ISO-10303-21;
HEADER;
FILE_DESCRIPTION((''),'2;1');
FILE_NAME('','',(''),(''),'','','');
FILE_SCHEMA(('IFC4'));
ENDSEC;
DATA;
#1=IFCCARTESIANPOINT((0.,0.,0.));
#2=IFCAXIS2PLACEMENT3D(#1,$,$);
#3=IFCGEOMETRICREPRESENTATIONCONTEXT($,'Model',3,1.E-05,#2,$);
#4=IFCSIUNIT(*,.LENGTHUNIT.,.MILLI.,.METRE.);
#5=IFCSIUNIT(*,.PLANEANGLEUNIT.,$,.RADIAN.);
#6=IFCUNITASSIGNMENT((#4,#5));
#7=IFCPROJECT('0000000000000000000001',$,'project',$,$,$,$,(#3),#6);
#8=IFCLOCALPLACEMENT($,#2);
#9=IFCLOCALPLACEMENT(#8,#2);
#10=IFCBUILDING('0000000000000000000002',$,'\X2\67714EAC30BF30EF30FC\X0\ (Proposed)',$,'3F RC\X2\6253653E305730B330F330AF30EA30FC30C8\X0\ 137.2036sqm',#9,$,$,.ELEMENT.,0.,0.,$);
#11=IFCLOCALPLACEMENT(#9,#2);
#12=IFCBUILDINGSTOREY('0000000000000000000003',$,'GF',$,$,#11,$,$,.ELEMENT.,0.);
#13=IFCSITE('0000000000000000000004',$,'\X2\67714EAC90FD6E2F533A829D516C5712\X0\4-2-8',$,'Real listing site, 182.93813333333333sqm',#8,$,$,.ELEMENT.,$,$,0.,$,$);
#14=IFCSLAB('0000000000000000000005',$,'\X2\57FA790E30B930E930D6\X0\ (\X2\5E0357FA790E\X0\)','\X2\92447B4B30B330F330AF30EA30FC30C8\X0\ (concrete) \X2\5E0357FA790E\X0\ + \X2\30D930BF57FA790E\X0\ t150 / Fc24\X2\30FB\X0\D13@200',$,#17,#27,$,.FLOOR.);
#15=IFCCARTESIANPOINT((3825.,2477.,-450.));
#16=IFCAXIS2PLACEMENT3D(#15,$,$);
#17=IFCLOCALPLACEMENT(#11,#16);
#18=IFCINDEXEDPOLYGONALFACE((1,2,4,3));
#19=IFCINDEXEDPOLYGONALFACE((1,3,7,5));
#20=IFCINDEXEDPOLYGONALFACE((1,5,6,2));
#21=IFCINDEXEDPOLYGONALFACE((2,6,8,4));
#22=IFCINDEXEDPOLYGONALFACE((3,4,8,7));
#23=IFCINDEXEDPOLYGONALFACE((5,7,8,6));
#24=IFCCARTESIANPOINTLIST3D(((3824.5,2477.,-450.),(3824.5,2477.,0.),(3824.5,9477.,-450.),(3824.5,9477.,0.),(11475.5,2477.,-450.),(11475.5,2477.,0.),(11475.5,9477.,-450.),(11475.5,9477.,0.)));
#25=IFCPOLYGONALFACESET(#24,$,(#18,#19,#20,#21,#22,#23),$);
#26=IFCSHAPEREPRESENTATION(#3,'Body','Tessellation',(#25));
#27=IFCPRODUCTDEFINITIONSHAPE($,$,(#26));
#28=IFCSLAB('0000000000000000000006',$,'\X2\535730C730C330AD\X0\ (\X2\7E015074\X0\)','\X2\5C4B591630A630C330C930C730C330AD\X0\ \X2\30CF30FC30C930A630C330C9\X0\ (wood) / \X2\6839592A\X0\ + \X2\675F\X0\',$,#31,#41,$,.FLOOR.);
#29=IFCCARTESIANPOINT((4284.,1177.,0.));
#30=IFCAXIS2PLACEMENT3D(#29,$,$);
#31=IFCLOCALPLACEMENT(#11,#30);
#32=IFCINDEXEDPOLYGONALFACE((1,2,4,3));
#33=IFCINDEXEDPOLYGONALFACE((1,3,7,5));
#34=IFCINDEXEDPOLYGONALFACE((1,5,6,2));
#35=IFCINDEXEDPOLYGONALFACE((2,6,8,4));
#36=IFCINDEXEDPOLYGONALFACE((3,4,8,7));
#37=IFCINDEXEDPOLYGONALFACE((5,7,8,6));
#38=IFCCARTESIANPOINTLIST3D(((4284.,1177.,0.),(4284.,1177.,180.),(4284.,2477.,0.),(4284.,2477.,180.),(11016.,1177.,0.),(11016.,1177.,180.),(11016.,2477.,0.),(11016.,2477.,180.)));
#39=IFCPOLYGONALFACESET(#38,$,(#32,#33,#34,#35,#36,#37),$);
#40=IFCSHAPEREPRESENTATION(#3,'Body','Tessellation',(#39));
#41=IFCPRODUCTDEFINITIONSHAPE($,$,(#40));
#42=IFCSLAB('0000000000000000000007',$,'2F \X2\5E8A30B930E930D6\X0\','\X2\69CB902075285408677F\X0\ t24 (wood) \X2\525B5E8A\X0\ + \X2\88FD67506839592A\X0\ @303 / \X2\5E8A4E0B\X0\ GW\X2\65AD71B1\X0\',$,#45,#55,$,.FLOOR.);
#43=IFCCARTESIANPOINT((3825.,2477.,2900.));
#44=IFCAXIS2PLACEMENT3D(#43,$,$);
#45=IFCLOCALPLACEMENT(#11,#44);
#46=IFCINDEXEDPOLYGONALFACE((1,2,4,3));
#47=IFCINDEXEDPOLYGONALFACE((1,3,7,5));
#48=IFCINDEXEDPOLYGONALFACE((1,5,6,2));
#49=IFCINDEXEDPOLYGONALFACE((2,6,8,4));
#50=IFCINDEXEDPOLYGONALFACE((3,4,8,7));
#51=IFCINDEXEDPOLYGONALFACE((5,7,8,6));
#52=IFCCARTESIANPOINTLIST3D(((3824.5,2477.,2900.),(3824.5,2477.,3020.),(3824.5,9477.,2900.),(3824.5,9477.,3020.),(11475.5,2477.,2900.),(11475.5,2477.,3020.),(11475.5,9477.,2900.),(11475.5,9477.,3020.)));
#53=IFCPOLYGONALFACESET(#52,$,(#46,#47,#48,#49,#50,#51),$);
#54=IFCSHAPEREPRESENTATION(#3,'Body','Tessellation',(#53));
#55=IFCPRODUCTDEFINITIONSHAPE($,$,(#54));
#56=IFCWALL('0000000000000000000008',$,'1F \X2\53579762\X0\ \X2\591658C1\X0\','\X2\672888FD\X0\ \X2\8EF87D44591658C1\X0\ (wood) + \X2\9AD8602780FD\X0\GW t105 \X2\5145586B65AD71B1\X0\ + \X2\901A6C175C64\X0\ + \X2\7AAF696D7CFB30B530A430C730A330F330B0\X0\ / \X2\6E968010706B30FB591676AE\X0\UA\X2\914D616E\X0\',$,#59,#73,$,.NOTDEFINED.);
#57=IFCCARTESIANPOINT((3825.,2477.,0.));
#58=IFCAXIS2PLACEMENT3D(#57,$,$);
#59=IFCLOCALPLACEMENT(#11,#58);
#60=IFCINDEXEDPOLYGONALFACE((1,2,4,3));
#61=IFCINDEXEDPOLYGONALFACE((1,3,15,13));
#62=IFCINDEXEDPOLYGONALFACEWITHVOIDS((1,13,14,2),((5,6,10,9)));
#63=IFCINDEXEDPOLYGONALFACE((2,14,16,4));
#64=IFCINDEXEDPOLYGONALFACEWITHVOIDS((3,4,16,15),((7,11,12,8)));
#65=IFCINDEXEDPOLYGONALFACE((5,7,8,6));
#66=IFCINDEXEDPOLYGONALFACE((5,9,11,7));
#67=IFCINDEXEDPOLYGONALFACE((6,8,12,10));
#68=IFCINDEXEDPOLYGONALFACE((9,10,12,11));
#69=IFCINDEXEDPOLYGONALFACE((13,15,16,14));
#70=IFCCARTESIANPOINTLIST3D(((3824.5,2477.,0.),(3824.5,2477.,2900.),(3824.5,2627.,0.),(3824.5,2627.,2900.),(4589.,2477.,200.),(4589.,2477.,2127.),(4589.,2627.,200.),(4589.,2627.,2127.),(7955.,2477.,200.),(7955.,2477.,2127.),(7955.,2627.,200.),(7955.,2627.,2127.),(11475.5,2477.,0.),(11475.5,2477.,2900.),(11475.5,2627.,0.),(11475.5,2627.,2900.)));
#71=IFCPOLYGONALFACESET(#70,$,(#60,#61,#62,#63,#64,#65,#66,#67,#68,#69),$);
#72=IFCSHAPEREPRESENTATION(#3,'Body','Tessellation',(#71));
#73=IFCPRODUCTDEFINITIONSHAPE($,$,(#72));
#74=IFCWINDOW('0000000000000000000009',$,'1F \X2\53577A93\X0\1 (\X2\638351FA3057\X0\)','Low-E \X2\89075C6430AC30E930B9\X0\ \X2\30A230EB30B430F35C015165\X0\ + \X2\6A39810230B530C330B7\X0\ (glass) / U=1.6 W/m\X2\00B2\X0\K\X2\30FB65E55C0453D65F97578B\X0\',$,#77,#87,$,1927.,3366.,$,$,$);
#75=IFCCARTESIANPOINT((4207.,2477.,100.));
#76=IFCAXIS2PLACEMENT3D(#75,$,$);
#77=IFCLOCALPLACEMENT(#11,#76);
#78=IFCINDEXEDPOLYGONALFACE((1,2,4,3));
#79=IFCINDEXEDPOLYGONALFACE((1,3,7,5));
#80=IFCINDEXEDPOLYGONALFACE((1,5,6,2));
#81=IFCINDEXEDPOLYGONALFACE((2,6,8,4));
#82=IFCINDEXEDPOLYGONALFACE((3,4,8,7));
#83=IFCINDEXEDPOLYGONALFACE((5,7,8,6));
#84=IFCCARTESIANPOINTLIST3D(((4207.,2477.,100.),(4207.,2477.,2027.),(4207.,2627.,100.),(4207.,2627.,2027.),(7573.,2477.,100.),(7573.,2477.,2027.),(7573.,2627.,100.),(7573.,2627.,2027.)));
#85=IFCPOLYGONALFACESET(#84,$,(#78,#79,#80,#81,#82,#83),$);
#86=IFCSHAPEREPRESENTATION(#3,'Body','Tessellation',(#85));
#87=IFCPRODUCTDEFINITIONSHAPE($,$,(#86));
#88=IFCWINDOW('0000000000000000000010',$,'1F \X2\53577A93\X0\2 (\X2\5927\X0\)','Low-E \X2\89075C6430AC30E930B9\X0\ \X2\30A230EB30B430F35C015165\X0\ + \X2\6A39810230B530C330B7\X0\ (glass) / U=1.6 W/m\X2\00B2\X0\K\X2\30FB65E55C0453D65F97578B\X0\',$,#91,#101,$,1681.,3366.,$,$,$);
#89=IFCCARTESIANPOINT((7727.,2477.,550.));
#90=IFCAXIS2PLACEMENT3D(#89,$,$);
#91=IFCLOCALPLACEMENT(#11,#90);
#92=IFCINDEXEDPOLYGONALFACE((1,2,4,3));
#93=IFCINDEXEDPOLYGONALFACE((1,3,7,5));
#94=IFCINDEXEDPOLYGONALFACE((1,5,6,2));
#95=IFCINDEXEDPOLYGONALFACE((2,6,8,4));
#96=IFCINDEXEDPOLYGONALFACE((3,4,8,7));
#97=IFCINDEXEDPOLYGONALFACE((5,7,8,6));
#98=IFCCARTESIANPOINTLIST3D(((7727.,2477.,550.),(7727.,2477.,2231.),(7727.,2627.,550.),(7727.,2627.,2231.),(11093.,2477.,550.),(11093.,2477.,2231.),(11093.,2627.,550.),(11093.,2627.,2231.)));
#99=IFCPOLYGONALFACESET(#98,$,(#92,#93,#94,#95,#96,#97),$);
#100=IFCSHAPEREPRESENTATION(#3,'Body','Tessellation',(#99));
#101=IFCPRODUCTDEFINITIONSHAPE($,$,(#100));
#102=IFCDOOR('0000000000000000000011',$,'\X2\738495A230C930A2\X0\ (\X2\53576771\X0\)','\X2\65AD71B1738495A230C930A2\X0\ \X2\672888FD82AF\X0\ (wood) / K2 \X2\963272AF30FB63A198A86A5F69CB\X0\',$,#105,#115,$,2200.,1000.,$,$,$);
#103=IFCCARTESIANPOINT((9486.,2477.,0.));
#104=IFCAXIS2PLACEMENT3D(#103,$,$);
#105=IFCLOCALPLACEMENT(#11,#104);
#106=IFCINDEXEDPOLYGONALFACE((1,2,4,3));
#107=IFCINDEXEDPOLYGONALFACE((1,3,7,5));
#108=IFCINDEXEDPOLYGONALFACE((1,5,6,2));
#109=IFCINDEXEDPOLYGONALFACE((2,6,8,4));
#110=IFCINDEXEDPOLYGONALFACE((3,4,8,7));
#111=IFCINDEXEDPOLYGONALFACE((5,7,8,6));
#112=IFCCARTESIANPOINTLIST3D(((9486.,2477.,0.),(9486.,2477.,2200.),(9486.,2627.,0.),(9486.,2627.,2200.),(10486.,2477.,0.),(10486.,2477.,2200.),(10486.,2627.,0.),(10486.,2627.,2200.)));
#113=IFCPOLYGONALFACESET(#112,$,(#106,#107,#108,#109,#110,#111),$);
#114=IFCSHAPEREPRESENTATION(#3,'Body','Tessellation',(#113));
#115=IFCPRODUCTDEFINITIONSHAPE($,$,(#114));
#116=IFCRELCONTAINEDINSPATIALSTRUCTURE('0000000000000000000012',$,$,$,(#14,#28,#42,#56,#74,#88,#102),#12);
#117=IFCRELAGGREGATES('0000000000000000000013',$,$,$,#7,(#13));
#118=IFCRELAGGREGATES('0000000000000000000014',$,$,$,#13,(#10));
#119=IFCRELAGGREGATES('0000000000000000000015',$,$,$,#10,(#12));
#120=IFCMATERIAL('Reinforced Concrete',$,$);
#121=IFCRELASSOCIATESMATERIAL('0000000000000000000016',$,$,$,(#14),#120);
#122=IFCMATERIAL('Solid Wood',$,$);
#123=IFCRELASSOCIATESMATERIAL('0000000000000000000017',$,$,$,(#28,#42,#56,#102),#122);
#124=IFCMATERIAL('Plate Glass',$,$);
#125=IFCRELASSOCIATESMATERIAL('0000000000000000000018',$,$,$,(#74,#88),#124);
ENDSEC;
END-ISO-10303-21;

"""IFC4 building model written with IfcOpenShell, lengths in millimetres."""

from ifc_helpers import new_model, si_unit, frame, frame_2d, origin, place, context, project, spatial, rectangle, extrude, material, element, fill, save


model = new_model("IFC4")

# Units and contexts
model_context = context("Model", 3, precision=1e-05, world=origin())
ifc_project = project(units=[si_unit("LENGTHUNIT", "METRE", prefix="MILLI"), si_unit("PLANEANGLEUNIT", "RADIAN")], contexts=[model_context])

# Site, building, storey
site_placement = place(None, origin())
site = spatial("IfcSite", under=ifc_project, at=site_placement, Name="東京都港区芝公園4-2-8", ObjectType="Real listing site, 182.93813333333333sqm", CompositionType="ELEMENT", RefElevation=0.0)
building_placement = place(site_placement, origin())
building = spatial("IfcBuilding", under=site, at=building_placement, Name="東京タワー (Proposed)", ObjectType="3F RC打放しコンクリート 137.2036sqm", CompositionType="ELEMENT", ElevationOfRefHeight=0.0, ElevationOfTerrain=0.0)
storey_placement = place(building_placement, origin())
storey = spatial("IfcBuildingStorey", under=building, at=storey_placement, Name="GF", CompositionType="ELEMENT", Elevation=0.0)

# Slabs
ifc_material_1 = material(Name="Reinforced Concrete")
slab_1_placement = place(storey_placement, frame((3825.0, 2477.0, -450.0)))
element("IfcSlab", 1, at=slab_1_placement, inside=storey, material=ifc_material_1, Name="基礎スラブ (布基礎)", Description="鉄筋コンクリート (concrete) 布基礎 + ベタ基礎 t150 / Fc24・D13@200", PredefinedType="FLOOR", context=model_context, shape_type="SweptSolid", body=[
    extrude(rectangle(XDim=7651.0, YDim=7000.0, at=frame_2d((3825.0, 3500.0))), frame((3825.0, 2477.0, -450.0)), (0.0, 0.0, 1.0), 450.0),
])
ifc_material_2 = material(Name="Solid Wood")
slab_2_placement = place(storey_placement, frame((4284.0, 1177.0, 0.0)))
element("IfcSlab", 2, at=slab_2_placement, inside=storey, material=ifc_material_2, Name="南デッキ (縁側)", Description="屋外ウッドデッキ ハードウッド (wood) / 根太 + 束", PredefinedType="FLOOR", context=model_context, shape_type="SweptSolid", body=[
    extrude(rectangle(XDim=6732.0, YDim=1300.0, at=frame_2d((3366.0, 650.0))), frame((4284.0, 1177.0, 0.0)), (0.0, 0.0, 1.0), 180.0),
])
slab_3_placement = place(storey_placement, frame((3825.0, 2477.0, 2900.0)))
element("IfcSlab", 3, at=slab_3_placement, inside=storey, material=ifc_material_2, Name="2F 床スラブ", Description="構造用合板 t24 (wood) 剛床 + 製材根太 @303 / 床下 GW断熱", PredefinedType="FLOOR", context=model_context, shape_type="SweptSolid", body=[
    extrude(rectangle(XDim=7651.0, YDim=7000.0, at=frame_2d((3825.0, 3500.0))), frame((3825.0, 2477.0, 2900.0)), (0.0, 0.0, 1.0), 120.0),
])

# Wall, openings, windows, door
wall_1_placement = place(storey_placement, frame((3825.0, 2477.0, 0.0)))
wall_1 = element("IfcWall", 4, at=wall_1_placement, inside=storey, material=ifc_material_2, Name="1F 南面 外壁", Description="木製 軸組外壁 (wood) + 高性能GW t105 充填断熱 + 通気層 + 窯業系サイディング / 準耐火・外皮UA配慮", PredefinedType="NOTDEFINED", context=model_context, shape_type="SweptSolid", body=[
    extrude(rectangle(XDim=7651.0, YDim=150.0, at=frame_2d((3825.0, 75.0))), frame((3825.0, 2477.0, 0.0)), (0.0, 0.0, 1.0), 2900.0),
])
opening_1_placement = place(storey_placement, frame((4207.0, 2477.0, 100.0)))
opening_1 = element("IfcOpeningElement", 5, at=opening_1_placement, cuts=wall_1, PredefinedType="NOTDEFINED", context=model_context, shape_type="SweptSolid", body=[
    extrude(rectangle(XDim=3366.0, YDim=150.0, at=frame_2d((1683.0, 75.0))), frame((4207.0, 2477.0, 100.0)), (0.0, 0.0, 1.0), 1927.0),
])
opening_2_placement = place(storey_placement, frame((7727.0, 2477.0, 550.0)))
opening_2 = element("IfcOpeningElement", 6, at=opening_2_placement, cuts=wall_1, PredefinedType="NOTDEFINED", context=model_context, shape_type="SweptSolid", body=[
    extrude(rectangle(XDim=3366.0, YDim=150.0, at=frame_2d((1683.0, 75.0))), frame((7727.0, 2477.0, 550.0)), (0.0, 0.0, 1.0), 1681.0),
])
opening_3_placement = place(storey_placement, frame((9486.0, 2477.0, 0.0)))
opening_3 = element("IfcOpeningElement", 7, at=opening_3_placement, cuts=wall_1, PredefinedType="NOTDEFINED", context=model_context, shape_type="SweptSolid", body=[
    extrude(rectangle(XDim=1000.0, YDim=150.0, at=frame_2d((500.0, 75.0))), frame((9486.0, 2477.0, 0.0)), (0.0, 0.0, 1.0), 2200.0),
])
ifc_material_3 = material(Name="Plate Glass")
window_1_placement = place(storey_placement, frame((4207.0, 2477.0, 100.0)))
window_1 = element("IfcWindow", 8, at=window_1_placement, inside=storey, material=ifc_material_3, Name="1F 南窓1 (掃出し)", Description="Low-E 複層ガラス アルゴン封入 + 樹脂サッシ (glass) / U=1.6 W/m²K・日射取得型", OverallHeight=1927.0, OverallWidth=3366.0, context=model_context, shape_type="SweptSolid", body=[
    extrude(rectangle(XDim=3366.0, YDim=150.0, at=frame_2d((1683.0, 75.0))), frame((4207.0, 2477.0, 100.0)), (0.0, 0.0, 1.0), 1927.0),
])
fill(opening_1, window_1)
window_2_placement = place(storey_placement, frame((7727.0, 2477.0, 550.0)))
window_2 = element("IfcWindow", 9, at=window_2_placement, inside=storey, material=ifc_material_3, Name="1F 南窓2 (大)", Description="Low-E 複層ガラス アルゴン封入 + 樹脂サッシ (glass) / U=1.6 W/m²K・日射取得型", OverallHeight=1681.0, OverallWidth=3366.0, context=model_context, shape_type="SweptSolid", body=[
    extrude(rectangle(XDim=3366.0, YDim=150.0, at=frame_2d((1683.0, 75.0))), frame((7727.0, 2477.0, 550.0)), (0.0, 0.0, 1.0), 1681.0),
])
fill(opening_2, window_2)
door_1_placement = place(storey_placement, frame((9486.0, 2477.0, 0.0)))
door_1 = element("IfcDoor", 10, at=door_1_placement, inside=storey, material=ifc_material_2, Name="玄関ドア (南東)", Description="断熱玄関ドア 木製芯 (wood) / K2 防犯・採風機構", OverallHeight=2200.0, OverallWidth=1000.0, context=model_context, shape_type="SweptSolid", body=[
    extrude(rectangle(XDim=1000.0, YDim=150.0, at=frame_2d((500.0, 75.0))), frame((9486.0, 2477.0, 0.0)), (0.0, 0.0, 1.0), 2200.0),
])
fill(opening_3, door_1)

save(model, "model.ifc")
